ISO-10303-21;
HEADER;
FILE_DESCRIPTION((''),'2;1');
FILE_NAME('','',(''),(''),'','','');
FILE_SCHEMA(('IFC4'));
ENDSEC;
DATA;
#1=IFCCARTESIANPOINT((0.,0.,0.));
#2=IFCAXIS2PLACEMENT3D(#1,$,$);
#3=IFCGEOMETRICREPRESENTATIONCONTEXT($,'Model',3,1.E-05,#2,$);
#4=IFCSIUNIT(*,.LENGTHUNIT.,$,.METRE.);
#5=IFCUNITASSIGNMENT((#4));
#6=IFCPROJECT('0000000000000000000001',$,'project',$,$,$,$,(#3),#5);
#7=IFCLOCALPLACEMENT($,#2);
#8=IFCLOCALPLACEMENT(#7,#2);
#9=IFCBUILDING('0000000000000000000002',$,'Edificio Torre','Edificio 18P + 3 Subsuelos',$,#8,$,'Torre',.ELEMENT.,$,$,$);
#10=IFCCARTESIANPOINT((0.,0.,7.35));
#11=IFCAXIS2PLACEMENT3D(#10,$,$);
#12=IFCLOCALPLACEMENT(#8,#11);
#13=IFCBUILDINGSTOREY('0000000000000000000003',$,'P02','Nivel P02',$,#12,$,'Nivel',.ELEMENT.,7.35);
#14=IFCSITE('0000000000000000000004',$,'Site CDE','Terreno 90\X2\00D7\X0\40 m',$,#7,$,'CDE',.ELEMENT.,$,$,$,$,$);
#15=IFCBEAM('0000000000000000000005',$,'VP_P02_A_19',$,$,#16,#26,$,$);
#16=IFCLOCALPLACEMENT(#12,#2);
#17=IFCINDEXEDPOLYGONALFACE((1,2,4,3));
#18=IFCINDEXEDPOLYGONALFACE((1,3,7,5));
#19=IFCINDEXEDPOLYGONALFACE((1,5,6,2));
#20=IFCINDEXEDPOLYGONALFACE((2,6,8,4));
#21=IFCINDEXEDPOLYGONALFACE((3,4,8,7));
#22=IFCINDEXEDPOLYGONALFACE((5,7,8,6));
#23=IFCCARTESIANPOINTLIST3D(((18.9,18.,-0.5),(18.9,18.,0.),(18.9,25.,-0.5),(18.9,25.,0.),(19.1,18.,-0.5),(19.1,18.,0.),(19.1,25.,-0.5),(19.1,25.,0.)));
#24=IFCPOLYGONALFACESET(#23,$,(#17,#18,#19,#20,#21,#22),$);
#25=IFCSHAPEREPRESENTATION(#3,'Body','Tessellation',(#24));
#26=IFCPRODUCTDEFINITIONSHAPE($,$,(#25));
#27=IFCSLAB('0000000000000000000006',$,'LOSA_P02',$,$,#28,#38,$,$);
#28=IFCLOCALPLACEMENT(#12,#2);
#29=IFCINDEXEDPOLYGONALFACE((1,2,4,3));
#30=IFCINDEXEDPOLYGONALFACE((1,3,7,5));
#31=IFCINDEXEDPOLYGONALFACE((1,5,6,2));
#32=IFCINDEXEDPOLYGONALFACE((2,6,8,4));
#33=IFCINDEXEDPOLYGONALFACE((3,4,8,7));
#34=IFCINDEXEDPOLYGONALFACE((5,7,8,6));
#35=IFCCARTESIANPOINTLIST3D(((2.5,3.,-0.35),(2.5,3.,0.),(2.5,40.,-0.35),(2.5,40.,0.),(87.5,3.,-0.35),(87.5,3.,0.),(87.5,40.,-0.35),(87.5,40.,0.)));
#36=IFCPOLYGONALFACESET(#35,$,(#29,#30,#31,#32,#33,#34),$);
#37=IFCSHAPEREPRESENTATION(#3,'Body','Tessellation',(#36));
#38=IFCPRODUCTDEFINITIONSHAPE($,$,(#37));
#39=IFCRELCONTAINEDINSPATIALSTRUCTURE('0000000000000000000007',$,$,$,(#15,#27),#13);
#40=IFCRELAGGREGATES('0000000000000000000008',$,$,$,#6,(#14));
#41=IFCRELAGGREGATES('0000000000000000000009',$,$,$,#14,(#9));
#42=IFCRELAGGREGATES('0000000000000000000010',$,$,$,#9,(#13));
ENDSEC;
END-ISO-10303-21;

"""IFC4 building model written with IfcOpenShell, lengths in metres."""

from ifc_helpers import new_model, si_unit, frame, origin, origin_2d, place, context, project, spatial, rectangle, extrude, element, save


model = new_model("IFC4")

# Units and contexts
model_context = context("Model", 3, precision=1e-05, world=origin())
ifc_project = project(units=[si_unit("LENGTHUNIT", "METRE")], contexts=[model_context])

# Site, building, storey
site_placement = place(None, origin())
site = spatial("IfcSite", under=ifc_project, at=site_placement, Name="Site CDE", Description="Terreno 90×40 m", LongName="CDE", CompositionType="ELEMENT")
building_placement = place(site_placement, origin())
building = spatial("IfcBuilding", under=site, at=building_placement, Name="Edificio Torre", Description="Edificio 18P + 3 Subsuelos", LongName="Torre", CompositionType="ELEMENT")
storey_placement = place(building_placement, frame((0.0, 0.0, 7.35)))
storey = spatial("IfcBuildingStorey", under=building, at=storey_placement, Name="P02", Description="Nivel P02", LongName="Nivel", CompositionType="ELEMENT", Elevation=7.35)

# Beam
beam_1_placement = place(storey_placement, frame((19.0, 21.5, -0.5)))
element("IfcBeam", 1, at=beam_1_placement, inside=storey, Name="VP_P02_A_19", context=model_context, shape_type="SweptSolid", body=[
    extrude(rectangle(XDim=0.2, YDim=7.0, at=origin_2d()), origin(), (0.0, 0.0, 1.0), 0.5),
])

# Slab
slab_placement = place(storey_placement, frame((45.0, 21.5, -0.35)))
element("IfcSlab", 2, at=slab_placement, inside=storey, Name="LOSA_P02", context=model_context, shape_type="SweptSolid", body=[
    extrude(rectangle(XDim=85.0, YDim=37.0, at=origin_2d()), origin(), (0.0, 0.0, 1.0), 0.35),
])

save(model, "model.ifc")
